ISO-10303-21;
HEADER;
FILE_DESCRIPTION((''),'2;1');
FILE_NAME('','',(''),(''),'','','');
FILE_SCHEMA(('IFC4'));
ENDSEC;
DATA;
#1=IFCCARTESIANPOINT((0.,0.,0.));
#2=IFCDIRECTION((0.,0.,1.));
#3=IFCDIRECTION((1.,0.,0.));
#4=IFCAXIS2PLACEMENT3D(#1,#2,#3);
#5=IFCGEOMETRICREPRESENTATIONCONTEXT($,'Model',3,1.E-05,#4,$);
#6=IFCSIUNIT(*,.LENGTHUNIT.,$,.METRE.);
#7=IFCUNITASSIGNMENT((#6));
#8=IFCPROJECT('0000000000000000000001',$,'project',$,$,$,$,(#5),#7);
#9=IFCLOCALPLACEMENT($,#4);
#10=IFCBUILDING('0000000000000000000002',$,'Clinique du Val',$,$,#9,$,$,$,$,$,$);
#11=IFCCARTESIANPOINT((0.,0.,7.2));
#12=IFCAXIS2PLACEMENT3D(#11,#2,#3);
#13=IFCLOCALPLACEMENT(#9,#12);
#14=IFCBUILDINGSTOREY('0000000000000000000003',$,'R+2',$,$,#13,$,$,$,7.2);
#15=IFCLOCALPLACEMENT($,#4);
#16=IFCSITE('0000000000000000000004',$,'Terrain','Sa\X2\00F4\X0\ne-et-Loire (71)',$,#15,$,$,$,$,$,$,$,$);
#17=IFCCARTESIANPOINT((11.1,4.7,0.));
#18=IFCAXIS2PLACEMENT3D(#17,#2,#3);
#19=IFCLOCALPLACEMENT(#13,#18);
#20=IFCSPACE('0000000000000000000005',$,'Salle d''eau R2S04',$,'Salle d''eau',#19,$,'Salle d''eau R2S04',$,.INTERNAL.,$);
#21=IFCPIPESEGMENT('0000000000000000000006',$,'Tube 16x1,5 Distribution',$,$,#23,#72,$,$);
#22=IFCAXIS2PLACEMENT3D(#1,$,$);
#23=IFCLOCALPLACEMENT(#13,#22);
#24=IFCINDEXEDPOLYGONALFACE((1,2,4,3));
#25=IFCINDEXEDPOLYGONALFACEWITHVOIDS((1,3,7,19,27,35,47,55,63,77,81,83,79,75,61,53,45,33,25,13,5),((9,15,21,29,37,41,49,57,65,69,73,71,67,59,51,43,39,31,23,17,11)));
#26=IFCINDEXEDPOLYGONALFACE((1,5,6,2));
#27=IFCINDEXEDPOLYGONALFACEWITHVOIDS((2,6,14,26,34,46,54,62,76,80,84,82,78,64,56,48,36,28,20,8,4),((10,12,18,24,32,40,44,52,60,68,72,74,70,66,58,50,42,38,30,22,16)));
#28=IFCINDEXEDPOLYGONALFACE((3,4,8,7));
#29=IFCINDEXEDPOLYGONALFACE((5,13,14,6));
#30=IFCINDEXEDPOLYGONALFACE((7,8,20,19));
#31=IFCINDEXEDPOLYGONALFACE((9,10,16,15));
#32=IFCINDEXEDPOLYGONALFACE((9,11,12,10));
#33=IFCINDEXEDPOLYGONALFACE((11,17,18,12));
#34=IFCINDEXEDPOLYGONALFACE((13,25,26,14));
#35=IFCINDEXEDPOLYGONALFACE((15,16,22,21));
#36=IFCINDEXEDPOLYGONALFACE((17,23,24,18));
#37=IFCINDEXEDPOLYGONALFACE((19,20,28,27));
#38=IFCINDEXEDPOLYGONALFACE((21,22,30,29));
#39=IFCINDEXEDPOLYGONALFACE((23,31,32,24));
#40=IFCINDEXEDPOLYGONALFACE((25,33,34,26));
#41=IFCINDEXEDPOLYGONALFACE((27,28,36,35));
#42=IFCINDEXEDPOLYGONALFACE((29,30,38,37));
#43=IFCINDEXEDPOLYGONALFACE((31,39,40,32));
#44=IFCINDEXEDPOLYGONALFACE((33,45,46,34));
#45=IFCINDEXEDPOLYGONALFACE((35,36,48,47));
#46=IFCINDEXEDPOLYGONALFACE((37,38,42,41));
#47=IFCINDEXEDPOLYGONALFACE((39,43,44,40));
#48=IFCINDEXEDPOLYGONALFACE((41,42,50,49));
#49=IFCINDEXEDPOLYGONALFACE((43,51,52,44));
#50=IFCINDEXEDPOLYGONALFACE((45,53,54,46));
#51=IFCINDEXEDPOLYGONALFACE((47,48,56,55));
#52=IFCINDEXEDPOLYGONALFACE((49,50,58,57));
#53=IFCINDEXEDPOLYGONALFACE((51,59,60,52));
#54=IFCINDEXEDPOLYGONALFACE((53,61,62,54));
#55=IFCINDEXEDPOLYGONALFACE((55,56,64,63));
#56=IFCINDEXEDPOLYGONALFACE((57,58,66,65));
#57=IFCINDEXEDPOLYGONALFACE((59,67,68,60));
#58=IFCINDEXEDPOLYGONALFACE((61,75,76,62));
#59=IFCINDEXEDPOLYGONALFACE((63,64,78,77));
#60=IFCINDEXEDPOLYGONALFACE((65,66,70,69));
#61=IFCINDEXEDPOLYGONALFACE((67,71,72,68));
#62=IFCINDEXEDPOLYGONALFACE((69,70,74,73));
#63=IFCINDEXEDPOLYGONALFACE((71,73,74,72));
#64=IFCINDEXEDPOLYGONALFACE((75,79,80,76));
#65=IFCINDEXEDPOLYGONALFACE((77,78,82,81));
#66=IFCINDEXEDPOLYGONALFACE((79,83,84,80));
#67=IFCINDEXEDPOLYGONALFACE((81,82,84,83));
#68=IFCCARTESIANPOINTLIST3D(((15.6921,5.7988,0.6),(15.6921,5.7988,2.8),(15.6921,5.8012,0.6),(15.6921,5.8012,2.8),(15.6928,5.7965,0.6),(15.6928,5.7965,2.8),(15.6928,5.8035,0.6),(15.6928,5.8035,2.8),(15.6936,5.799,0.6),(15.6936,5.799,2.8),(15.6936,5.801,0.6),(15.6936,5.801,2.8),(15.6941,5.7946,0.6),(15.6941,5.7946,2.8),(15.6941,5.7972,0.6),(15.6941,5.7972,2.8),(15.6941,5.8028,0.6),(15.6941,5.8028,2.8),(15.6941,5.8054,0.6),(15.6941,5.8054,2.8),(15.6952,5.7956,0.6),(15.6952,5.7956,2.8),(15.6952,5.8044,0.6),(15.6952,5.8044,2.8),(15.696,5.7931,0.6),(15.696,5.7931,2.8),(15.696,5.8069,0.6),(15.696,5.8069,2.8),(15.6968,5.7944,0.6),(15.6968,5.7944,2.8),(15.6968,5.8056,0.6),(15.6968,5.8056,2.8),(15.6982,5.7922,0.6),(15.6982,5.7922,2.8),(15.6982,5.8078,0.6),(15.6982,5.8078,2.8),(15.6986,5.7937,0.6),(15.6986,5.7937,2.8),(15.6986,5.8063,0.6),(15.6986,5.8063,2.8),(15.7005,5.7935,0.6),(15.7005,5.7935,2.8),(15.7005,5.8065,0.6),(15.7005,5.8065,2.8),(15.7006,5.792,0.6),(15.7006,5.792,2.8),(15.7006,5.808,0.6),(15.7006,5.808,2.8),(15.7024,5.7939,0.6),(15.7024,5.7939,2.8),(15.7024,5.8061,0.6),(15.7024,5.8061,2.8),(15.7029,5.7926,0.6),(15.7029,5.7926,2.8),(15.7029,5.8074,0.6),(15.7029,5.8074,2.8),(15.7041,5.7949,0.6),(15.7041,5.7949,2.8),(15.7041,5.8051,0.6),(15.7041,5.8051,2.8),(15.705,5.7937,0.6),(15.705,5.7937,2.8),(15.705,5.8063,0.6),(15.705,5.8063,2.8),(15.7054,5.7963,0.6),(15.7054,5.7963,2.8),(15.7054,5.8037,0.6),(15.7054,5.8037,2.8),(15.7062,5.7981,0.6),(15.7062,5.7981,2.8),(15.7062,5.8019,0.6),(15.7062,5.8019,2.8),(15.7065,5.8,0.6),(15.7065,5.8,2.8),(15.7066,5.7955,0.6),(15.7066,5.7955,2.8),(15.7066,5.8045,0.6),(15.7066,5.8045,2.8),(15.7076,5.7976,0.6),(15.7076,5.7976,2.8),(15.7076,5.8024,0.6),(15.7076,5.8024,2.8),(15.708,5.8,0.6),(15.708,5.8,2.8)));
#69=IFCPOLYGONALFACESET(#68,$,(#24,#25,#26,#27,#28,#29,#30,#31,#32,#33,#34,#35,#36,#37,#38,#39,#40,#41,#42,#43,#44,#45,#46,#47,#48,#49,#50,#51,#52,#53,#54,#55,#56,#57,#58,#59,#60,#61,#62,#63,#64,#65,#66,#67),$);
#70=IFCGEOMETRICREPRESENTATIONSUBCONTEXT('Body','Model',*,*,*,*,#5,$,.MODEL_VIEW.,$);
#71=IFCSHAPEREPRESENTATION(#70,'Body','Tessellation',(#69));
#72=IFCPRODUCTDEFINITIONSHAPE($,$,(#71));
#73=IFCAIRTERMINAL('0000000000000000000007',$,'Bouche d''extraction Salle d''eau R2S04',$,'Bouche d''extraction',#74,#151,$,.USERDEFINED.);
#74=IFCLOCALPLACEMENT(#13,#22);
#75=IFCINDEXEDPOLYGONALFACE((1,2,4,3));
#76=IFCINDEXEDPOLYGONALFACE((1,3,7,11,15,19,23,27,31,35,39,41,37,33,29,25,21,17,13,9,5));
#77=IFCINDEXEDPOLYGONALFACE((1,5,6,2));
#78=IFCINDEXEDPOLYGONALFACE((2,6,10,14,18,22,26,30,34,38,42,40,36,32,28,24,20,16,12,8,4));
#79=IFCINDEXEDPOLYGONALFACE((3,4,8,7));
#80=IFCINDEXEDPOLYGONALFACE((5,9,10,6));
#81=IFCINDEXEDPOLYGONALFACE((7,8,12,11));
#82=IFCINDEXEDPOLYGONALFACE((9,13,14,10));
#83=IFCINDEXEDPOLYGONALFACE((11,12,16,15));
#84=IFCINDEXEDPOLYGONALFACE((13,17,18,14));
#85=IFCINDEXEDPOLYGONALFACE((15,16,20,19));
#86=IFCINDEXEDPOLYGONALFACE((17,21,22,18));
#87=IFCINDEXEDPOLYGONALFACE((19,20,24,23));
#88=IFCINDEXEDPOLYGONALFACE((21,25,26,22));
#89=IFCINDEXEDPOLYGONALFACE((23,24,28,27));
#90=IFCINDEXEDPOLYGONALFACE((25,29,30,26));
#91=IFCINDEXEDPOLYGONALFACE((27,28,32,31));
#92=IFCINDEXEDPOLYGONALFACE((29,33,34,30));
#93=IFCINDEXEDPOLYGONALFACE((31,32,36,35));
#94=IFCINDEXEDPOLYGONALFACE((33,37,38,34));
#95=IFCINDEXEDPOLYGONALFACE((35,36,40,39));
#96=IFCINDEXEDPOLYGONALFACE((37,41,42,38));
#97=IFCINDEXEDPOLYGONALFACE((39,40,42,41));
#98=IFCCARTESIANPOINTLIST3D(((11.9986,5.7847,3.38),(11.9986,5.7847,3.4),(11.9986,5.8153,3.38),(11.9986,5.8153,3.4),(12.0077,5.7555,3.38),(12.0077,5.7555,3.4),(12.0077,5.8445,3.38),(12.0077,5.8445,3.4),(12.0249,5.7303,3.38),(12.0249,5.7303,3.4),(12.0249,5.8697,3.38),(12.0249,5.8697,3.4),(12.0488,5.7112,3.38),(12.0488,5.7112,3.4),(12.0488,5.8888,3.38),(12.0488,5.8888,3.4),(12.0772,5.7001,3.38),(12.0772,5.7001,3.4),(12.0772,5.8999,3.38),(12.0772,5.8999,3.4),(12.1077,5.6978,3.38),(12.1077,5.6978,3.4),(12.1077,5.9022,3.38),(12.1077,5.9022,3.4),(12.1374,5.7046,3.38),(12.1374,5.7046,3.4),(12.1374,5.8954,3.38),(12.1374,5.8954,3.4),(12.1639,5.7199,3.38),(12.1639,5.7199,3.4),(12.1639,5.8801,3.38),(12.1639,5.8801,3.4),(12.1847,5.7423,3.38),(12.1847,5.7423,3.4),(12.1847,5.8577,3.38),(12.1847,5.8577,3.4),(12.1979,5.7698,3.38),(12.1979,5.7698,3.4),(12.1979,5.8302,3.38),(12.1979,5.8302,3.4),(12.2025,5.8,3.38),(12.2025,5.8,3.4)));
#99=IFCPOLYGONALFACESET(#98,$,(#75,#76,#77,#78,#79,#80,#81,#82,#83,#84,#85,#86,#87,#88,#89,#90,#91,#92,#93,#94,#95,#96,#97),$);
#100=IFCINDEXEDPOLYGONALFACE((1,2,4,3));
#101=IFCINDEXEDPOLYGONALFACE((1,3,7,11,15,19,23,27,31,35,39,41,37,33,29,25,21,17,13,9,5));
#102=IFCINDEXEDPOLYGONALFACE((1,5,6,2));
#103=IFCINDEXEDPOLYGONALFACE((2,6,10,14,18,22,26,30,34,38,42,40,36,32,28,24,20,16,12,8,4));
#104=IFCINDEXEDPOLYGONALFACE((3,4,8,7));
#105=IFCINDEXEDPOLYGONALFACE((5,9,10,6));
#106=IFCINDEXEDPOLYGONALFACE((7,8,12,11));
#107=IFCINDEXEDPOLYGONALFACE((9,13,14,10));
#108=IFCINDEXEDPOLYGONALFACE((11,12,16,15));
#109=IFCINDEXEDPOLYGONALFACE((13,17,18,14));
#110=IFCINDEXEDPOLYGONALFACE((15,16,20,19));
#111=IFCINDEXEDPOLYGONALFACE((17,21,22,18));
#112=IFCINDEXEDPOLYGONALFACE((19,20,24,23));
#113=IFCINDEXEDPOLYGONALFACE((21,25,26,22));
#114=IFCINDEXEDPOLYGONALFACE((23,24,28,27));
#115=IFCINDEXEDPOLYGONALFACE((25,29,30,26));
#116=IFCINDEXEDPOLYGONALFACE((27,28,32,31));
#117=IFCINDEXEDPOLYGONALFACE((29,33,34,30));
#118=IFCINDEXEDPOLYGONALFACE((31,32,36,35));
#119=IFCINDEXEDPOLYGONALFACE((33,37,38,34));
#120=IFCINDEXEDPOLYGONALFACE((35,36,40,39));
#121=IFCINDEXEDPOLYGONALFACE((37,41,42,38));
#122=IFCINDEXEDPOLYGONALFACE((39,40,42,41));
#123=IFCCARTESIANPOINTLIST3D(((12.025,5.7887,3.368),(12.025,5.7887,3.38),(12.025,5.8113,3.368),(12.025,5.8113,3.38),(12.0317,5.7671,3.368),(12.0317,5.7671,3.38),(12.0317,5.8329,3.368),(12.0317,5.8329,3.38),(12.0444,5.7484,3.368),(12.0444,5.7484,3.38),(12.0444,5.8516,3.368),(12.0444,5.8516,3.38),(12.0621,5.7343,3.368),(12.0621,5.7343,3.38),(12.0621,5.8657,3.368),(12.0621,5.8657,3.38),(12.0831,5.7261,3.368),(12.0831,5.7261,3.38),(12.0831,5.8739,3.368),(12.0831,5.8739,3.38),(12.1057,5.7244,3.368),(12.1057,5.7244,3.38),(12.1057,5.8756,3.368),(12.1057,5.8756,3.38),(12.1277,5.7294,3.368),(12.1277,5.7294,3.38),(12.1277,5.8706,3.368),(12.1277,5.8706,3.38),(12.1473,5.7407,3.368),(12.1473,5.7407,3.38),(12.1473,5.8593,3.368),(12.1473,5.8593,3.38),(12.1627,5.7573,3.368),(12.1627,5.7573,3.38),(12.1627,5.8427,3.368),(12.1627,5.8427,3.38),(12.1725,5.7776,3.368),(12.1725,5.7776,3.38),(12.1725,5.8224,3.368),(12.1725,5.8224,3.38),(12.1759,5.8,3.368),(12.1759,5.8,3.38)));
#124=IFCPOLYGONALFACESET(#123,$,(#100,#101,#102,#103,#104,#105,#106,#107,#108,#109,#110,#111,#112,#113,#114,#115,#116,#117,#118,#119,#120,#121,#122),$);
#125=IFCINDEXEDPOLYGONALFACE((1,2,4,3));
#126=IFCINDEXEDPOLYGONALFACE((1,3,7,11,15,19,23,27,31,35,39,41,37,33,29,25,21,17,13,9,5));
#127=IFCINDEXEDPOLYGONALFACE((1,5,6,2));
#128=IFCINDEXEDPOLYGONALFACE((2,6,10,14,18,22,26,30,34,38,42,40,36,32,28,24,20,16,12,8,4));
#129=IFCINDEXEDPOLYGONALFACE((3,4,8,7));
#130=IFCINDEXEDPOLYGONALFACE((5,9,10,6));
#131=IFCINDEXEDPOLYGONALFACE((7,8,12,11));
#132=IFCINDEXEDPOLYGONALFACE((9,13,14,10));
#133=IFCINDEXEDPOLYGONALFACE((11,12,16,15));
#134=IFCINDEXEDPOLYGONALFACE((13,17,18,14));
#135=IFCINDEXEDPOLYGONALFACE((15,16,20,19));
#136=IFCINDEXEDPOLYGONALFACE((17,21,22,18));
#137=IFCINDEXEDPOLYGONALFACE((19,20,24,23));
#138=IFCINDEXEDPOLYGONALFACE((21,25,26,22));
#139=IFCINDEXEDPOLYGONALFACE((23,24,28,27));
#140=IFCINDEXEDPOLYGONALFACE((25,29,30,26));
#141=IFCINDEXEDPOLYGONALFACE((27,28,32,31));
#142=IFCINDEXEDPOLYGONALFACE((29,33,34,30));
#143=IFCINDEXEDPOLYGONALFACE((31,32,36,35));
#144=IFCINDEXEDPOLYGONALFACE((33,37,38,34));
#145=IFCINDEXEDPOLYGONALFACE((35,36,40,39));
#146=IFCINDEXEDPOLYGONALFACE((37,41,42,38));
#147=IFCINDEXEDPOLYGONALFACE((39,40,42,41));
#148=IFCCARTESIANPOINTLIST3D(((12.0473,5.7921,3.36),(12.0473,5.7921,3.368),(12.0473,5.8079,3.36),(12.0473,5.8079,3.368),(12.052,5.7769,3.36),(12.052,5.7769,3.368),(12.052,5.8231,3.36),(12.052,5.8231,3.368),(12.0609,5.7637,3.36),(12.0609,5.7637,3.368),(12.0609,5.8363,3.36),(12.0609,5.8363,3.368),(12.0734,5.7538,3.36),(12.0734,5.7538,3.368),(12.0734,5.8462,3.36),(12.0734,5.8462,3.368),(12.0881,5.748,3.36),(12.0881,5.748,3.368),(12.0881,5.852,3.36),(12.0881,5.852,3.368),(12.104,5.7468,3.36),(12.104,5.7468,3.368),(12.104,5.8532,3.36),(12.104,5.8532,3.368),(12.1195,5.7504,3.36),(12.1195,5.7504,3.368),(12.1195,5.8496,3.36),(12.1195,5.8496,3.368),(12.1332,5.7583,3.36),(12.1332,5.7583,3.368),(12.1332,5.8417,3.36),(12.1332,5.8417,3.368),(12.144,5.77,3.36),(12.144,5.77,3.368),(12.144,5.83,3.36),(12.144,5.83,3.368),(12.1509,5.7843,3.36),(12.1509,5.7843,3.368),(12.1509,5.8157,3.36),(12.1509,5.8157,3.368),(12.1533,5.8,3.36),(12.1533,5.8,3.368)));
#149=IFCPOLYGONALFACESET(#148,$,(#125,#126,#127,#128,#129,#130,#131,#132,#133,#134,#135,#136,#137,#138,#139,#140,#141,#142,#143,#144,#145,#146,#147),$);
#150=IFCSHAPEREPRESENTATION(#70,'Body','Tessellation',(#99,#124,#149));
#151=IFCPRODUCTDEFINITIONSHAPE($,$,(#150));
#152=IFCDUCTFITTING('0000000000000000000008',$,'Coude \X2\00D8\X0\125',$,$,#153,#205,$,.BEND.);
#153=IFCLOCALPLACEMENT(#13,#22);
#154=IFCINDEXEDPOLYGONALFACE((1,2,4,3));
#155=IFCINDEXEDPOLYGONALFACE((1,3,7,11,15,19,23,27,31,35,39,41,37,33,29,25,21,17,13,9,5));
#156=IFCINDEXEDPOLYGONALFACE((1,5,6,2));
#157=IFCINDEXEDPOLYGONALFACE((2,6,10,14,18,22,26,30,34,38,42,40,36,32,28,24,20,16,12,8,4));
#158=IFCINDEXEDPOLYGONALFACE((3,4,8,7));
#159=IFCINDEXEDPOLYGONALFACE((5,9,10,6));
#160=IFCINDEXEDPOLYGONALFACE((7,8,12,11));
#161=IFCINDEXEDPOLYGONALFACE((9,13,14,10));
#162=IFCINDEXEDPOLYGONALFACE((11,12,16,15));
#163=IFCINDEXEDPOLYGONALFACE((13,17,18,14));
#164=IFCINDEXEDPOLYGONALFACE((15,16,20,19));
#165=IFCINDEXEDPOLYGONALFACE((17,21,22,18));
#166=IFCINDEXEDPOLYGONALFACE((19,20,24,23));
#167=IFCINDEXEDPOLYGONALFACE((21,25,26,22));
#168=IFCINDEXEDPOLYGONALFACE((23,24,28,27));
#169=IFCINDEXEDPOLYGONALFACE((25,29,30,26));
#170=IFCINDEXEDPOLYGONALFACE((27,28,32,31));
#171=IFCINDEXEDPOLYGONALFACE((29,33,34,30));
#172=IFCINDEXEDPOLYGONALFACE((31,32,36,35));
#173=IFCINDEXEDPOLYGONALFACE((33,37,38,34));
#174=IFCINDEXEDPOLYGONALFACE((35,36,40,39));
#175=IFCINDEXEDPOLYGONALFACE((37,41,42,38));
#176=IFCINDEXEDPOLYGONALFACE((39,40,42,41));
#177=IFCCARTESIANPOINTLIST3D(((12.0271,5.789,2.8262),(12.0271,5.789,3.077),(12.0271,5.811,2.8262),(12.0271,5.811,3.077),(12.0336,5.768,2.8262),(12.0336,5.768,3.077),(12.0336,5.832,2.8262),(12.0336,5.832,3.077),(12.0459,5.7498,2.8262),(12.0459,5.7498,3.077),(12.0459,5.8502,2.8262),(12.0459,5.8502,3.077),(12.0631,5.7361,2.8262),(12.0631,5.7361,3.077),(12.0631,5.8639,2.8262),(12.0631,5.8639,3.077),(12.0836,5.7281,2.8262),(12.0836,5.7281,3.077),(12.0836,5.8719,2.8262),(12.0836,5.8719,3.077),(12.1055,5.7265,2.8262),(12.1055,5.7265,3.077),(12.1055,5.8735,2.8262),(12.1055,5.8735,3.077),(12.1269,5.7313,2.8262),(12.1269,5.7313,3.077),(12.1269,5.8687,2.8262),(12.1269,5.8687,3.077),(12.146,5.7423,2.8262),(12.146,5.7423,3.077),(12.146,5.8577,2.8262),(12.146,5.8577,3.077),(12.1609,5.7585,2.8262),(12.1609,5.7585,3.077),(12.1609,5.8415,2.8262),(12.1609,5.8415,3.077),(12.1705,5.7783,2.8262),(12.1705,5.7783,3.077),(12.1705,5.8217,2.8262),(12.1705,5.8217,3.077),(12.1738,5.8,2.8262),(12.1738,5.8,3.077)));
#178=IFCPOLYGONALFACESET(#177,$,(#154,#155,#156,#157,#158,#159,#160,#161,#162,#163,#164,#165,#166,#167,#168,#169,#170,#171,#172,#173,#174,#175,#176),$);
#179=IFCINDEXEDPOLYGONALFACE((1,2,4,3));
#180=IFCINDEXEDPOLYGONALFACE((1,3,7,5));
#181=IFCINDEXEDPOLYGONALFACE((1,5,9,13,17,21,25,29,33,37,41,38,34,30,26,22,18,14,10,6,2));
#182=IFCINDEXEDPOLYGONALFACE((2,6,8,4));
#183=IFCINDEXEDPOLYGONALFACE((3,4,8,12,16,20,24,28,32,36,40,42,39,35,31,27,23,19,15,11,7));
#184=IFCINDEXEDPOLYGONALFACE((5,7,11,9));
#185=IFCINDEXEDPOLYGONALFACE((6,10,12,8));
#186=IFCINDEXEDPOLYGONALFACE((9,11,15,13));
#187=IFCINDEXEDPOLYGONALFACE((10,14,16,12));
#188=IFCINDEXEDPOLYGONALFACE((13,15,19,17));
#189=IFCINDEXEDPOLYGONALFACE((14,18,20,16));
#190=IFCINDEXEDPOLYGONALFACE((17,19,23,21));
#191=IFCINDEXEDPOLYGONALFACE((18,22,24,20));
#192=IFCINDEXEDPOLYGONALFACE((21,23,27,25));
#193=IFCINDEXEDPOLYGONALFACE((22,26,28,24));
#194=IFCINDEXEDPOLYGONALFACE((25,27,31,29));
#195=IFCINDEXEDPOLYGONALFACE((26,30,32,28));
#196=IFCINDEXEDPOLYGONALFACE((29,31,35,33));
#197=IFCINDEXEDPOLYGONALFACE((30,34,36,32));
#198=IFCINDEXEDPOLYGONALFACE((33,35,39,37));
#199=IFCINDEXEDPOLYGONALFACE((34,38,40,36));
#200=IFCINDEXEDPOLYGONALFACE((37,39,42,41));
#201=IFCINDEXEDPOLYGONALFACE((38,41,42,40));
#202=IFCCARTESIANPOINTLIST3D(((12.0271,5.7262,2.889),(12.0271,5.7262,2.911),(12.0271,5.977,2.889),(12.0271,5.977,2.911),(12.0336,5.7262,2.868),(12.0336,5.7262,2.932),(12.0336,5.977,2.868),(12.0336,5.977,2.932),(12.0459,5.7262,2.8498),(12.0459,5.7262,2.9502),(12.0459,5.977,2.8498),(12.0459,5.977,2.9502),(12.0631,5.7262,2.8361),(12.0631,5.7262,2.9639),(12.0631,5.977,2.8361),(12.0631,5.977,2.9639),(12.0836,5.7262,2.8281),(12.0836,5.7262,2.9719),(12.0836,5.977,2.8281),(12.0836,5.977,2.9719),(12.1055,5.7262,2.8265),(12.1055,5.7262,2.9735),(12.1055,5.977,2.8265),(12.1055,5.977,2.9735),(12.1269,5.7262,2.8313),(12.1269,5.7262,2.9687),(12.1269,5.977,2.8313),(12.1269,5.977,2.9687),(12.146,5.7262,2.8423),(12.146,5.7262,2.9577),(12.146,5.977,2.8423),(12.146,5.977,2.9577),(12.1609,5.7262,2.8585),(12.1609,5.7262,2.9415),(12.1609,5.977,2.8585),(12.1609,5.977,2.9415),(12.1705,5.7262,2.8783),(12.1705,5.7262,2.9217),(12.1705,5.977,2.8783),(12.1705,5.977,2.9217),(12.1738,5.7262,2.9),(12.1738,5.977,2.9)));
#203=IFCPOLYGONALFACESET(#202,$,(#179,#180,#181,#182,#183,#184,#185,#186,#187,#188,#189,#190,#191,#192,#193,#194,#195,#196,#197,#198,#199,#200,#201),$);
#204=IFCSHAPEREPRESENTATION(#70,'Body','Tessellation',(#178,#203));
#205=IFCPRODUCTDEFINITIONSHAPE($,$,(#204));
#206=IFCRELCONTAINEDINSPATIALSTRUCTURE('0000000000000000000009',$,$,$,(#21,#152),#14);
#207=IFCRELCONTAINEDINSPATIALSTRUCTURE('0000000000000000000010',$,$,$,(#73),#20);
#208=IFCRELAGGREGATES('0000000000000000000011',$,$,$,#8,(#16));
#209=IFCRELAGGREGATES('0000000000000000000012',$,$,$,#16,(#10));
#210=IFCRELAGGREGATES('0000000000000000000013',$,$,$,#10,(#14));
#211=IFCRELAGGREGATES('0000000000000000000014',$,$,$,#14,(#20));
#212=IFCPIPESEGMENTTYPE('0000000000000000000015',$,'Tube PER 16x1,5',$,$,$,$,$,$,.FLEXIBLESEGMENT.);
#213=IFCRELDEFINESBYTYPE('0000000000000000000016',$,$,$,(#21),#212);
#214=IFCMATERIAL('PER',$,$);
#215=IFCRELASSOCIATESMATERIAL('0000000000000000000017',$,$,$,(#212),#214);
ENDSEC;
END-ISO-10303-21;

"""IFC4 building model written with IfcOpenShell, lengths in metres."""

from ifc_helpers import new_model, si_unit, frame, origin_with_axes, place, context, subcontext, project, spatial, circle, hollow_circle, extrude, material, type_object, element, save


model = new_model("IFC4")

# Units and contexts
model_context = context("Model", 3, precision=1e-05, world=origin_with_axes())
body_context = subcontext(model_context, "Body", "Model", "MODEL_VIEW")
ifc_project = project(units=[si_unit("LENGTHUNIT", "METRE")], contexts=[model_context])

# Site, building, storey
site_placement = place(None, origin_with_axes())
site = spatial("IfcSite", under=ifc_project, at=site_placement, Name="Terrain", Description="Saône-et-Loire (71)")
building_placement = place(None, origin_with_axes())
building = spatial("IfcBuilding", under=site, at=building_placement, Name="Clinique du Val")
storey_placement = place(building_placement, frame((0.0, 0.0, 7.2), z_axis=(0.0, 0.0, 1.0), x_axis=(1.0, 0.0, 0.0)))
storey = spatial("IfcBuildingStorey", under=building, at=storey_placement, Name="R+2", Elevation=7.2)

# Pipe segment
ifc_material_1 = material(Name="PER")
pipe_segment_type_1 = type_object("IfcPipeSegmentType", Name="Tube PER 16x1,5", PredefinedType="FLEXIBLESEGMENT", material=ifc_material_1)
pipe_segment_1_placement = place(storey_placement, frame((15.7, 5.8, 2.8), z_axis=(0.0, 0.0, -1.0), x_axis=(1.0, 0.0, 0.0)))
element("IfcPipeSegment", 1, at=pipe_segment_1_placement, inside=storey, type_object=pipe_segment_type_1, Name="Tube 16x1,5 Distribution", context=body_context, shape_type="SweptSolid", body=[
    extrude(hollow_circle(Radius=0.008, WallThickness=0.0015), origin_with_axes(), (0.0, 0.0, 1.0), 2.2),
])

# Shared definitions
space_1_placement = place(storey_placement, frame((11.1, 4.7, 0.0), z_axis=(0.0, 0.0, 1.0), x_axis=(1.0, 0.0, 0.0)))
space_1 = spatial("IfcSpace", under=storey, at=space_1_placement, Name="Salle d'eau R2S04", ObjectType="Salle d'eau", LongName="Salle d'eau R2S04", PredefinedType="INTERNAL")

# Air terminal
air_terminal_1_placement = place(space_1_placement, frame((1.0, 1.1, 3.36), z_axis=(0.0, 0.0, 1.0), x_axis=(1.0, 0.0, 0.0)))
element("IfcAirTerminal", 2, at=air_terminal_1_placement, inside=space_1, Name="Bouche d'extraction Salle d'eau R2S04", ObjectType="Bouche d'extraction", PredefinedType="USERDEFINED", context=body_context, shape_type="SweptSolid", body=[
    extrude(circle(Radius=0.1025), frame((0.0, 0.0, 0.02), z_axis=(0.0, 0.0, 1.0), x_axis=(1.0, 0.0, 0.0)), (0.0, 0.0, 1.0), 0.02),
    extrude(circle(Radius=0.0759), frame((0.0, 0.0, 0.008), z_axis=(0.0, 0.0, 1.0), x_axis=(1.0, 0.0, 0.0)), (0.0, 0.0, 1.0), 0.012),
    extrude(circle(Radius=0.0533), origin_with_axes(), (0.0, 0.0, 1.0), 0.008),
])

# Duct fitting
duct_fitting_placement = place(storey_placement, frame((12.1, 5.8, 2.9), z_axis=(0.0, 0.0, 1.0), x_axis=(1.0, 0.0, 0.0)))
element("IfcDuctFitting", 3, at=duct_fitting_placement, inside=storey, Name="Coude Ø125", PredefinedType="BEND", context=body_context, shape_type="SweptSolid", body=[
    extrude(circle(Radius=0.0737), frame((0.0, 0.0, -0.0737), z_axis=(0.0, 0.0, 1.0), x_axis=(1.0, 0.0, 0.0)), (0.0, 0.0, 1.0), 0.2507),
    extrude(circle(Radius=0.0737), frame((0.0, -0.0737, 0.0), z_axis=(0.0, 1.0, 0.0), x_axis=(1.0, 0.0, 0.0)), (0.0, 0.0, 1.0), 0.2507),
])

save(model, "model.ifc")
